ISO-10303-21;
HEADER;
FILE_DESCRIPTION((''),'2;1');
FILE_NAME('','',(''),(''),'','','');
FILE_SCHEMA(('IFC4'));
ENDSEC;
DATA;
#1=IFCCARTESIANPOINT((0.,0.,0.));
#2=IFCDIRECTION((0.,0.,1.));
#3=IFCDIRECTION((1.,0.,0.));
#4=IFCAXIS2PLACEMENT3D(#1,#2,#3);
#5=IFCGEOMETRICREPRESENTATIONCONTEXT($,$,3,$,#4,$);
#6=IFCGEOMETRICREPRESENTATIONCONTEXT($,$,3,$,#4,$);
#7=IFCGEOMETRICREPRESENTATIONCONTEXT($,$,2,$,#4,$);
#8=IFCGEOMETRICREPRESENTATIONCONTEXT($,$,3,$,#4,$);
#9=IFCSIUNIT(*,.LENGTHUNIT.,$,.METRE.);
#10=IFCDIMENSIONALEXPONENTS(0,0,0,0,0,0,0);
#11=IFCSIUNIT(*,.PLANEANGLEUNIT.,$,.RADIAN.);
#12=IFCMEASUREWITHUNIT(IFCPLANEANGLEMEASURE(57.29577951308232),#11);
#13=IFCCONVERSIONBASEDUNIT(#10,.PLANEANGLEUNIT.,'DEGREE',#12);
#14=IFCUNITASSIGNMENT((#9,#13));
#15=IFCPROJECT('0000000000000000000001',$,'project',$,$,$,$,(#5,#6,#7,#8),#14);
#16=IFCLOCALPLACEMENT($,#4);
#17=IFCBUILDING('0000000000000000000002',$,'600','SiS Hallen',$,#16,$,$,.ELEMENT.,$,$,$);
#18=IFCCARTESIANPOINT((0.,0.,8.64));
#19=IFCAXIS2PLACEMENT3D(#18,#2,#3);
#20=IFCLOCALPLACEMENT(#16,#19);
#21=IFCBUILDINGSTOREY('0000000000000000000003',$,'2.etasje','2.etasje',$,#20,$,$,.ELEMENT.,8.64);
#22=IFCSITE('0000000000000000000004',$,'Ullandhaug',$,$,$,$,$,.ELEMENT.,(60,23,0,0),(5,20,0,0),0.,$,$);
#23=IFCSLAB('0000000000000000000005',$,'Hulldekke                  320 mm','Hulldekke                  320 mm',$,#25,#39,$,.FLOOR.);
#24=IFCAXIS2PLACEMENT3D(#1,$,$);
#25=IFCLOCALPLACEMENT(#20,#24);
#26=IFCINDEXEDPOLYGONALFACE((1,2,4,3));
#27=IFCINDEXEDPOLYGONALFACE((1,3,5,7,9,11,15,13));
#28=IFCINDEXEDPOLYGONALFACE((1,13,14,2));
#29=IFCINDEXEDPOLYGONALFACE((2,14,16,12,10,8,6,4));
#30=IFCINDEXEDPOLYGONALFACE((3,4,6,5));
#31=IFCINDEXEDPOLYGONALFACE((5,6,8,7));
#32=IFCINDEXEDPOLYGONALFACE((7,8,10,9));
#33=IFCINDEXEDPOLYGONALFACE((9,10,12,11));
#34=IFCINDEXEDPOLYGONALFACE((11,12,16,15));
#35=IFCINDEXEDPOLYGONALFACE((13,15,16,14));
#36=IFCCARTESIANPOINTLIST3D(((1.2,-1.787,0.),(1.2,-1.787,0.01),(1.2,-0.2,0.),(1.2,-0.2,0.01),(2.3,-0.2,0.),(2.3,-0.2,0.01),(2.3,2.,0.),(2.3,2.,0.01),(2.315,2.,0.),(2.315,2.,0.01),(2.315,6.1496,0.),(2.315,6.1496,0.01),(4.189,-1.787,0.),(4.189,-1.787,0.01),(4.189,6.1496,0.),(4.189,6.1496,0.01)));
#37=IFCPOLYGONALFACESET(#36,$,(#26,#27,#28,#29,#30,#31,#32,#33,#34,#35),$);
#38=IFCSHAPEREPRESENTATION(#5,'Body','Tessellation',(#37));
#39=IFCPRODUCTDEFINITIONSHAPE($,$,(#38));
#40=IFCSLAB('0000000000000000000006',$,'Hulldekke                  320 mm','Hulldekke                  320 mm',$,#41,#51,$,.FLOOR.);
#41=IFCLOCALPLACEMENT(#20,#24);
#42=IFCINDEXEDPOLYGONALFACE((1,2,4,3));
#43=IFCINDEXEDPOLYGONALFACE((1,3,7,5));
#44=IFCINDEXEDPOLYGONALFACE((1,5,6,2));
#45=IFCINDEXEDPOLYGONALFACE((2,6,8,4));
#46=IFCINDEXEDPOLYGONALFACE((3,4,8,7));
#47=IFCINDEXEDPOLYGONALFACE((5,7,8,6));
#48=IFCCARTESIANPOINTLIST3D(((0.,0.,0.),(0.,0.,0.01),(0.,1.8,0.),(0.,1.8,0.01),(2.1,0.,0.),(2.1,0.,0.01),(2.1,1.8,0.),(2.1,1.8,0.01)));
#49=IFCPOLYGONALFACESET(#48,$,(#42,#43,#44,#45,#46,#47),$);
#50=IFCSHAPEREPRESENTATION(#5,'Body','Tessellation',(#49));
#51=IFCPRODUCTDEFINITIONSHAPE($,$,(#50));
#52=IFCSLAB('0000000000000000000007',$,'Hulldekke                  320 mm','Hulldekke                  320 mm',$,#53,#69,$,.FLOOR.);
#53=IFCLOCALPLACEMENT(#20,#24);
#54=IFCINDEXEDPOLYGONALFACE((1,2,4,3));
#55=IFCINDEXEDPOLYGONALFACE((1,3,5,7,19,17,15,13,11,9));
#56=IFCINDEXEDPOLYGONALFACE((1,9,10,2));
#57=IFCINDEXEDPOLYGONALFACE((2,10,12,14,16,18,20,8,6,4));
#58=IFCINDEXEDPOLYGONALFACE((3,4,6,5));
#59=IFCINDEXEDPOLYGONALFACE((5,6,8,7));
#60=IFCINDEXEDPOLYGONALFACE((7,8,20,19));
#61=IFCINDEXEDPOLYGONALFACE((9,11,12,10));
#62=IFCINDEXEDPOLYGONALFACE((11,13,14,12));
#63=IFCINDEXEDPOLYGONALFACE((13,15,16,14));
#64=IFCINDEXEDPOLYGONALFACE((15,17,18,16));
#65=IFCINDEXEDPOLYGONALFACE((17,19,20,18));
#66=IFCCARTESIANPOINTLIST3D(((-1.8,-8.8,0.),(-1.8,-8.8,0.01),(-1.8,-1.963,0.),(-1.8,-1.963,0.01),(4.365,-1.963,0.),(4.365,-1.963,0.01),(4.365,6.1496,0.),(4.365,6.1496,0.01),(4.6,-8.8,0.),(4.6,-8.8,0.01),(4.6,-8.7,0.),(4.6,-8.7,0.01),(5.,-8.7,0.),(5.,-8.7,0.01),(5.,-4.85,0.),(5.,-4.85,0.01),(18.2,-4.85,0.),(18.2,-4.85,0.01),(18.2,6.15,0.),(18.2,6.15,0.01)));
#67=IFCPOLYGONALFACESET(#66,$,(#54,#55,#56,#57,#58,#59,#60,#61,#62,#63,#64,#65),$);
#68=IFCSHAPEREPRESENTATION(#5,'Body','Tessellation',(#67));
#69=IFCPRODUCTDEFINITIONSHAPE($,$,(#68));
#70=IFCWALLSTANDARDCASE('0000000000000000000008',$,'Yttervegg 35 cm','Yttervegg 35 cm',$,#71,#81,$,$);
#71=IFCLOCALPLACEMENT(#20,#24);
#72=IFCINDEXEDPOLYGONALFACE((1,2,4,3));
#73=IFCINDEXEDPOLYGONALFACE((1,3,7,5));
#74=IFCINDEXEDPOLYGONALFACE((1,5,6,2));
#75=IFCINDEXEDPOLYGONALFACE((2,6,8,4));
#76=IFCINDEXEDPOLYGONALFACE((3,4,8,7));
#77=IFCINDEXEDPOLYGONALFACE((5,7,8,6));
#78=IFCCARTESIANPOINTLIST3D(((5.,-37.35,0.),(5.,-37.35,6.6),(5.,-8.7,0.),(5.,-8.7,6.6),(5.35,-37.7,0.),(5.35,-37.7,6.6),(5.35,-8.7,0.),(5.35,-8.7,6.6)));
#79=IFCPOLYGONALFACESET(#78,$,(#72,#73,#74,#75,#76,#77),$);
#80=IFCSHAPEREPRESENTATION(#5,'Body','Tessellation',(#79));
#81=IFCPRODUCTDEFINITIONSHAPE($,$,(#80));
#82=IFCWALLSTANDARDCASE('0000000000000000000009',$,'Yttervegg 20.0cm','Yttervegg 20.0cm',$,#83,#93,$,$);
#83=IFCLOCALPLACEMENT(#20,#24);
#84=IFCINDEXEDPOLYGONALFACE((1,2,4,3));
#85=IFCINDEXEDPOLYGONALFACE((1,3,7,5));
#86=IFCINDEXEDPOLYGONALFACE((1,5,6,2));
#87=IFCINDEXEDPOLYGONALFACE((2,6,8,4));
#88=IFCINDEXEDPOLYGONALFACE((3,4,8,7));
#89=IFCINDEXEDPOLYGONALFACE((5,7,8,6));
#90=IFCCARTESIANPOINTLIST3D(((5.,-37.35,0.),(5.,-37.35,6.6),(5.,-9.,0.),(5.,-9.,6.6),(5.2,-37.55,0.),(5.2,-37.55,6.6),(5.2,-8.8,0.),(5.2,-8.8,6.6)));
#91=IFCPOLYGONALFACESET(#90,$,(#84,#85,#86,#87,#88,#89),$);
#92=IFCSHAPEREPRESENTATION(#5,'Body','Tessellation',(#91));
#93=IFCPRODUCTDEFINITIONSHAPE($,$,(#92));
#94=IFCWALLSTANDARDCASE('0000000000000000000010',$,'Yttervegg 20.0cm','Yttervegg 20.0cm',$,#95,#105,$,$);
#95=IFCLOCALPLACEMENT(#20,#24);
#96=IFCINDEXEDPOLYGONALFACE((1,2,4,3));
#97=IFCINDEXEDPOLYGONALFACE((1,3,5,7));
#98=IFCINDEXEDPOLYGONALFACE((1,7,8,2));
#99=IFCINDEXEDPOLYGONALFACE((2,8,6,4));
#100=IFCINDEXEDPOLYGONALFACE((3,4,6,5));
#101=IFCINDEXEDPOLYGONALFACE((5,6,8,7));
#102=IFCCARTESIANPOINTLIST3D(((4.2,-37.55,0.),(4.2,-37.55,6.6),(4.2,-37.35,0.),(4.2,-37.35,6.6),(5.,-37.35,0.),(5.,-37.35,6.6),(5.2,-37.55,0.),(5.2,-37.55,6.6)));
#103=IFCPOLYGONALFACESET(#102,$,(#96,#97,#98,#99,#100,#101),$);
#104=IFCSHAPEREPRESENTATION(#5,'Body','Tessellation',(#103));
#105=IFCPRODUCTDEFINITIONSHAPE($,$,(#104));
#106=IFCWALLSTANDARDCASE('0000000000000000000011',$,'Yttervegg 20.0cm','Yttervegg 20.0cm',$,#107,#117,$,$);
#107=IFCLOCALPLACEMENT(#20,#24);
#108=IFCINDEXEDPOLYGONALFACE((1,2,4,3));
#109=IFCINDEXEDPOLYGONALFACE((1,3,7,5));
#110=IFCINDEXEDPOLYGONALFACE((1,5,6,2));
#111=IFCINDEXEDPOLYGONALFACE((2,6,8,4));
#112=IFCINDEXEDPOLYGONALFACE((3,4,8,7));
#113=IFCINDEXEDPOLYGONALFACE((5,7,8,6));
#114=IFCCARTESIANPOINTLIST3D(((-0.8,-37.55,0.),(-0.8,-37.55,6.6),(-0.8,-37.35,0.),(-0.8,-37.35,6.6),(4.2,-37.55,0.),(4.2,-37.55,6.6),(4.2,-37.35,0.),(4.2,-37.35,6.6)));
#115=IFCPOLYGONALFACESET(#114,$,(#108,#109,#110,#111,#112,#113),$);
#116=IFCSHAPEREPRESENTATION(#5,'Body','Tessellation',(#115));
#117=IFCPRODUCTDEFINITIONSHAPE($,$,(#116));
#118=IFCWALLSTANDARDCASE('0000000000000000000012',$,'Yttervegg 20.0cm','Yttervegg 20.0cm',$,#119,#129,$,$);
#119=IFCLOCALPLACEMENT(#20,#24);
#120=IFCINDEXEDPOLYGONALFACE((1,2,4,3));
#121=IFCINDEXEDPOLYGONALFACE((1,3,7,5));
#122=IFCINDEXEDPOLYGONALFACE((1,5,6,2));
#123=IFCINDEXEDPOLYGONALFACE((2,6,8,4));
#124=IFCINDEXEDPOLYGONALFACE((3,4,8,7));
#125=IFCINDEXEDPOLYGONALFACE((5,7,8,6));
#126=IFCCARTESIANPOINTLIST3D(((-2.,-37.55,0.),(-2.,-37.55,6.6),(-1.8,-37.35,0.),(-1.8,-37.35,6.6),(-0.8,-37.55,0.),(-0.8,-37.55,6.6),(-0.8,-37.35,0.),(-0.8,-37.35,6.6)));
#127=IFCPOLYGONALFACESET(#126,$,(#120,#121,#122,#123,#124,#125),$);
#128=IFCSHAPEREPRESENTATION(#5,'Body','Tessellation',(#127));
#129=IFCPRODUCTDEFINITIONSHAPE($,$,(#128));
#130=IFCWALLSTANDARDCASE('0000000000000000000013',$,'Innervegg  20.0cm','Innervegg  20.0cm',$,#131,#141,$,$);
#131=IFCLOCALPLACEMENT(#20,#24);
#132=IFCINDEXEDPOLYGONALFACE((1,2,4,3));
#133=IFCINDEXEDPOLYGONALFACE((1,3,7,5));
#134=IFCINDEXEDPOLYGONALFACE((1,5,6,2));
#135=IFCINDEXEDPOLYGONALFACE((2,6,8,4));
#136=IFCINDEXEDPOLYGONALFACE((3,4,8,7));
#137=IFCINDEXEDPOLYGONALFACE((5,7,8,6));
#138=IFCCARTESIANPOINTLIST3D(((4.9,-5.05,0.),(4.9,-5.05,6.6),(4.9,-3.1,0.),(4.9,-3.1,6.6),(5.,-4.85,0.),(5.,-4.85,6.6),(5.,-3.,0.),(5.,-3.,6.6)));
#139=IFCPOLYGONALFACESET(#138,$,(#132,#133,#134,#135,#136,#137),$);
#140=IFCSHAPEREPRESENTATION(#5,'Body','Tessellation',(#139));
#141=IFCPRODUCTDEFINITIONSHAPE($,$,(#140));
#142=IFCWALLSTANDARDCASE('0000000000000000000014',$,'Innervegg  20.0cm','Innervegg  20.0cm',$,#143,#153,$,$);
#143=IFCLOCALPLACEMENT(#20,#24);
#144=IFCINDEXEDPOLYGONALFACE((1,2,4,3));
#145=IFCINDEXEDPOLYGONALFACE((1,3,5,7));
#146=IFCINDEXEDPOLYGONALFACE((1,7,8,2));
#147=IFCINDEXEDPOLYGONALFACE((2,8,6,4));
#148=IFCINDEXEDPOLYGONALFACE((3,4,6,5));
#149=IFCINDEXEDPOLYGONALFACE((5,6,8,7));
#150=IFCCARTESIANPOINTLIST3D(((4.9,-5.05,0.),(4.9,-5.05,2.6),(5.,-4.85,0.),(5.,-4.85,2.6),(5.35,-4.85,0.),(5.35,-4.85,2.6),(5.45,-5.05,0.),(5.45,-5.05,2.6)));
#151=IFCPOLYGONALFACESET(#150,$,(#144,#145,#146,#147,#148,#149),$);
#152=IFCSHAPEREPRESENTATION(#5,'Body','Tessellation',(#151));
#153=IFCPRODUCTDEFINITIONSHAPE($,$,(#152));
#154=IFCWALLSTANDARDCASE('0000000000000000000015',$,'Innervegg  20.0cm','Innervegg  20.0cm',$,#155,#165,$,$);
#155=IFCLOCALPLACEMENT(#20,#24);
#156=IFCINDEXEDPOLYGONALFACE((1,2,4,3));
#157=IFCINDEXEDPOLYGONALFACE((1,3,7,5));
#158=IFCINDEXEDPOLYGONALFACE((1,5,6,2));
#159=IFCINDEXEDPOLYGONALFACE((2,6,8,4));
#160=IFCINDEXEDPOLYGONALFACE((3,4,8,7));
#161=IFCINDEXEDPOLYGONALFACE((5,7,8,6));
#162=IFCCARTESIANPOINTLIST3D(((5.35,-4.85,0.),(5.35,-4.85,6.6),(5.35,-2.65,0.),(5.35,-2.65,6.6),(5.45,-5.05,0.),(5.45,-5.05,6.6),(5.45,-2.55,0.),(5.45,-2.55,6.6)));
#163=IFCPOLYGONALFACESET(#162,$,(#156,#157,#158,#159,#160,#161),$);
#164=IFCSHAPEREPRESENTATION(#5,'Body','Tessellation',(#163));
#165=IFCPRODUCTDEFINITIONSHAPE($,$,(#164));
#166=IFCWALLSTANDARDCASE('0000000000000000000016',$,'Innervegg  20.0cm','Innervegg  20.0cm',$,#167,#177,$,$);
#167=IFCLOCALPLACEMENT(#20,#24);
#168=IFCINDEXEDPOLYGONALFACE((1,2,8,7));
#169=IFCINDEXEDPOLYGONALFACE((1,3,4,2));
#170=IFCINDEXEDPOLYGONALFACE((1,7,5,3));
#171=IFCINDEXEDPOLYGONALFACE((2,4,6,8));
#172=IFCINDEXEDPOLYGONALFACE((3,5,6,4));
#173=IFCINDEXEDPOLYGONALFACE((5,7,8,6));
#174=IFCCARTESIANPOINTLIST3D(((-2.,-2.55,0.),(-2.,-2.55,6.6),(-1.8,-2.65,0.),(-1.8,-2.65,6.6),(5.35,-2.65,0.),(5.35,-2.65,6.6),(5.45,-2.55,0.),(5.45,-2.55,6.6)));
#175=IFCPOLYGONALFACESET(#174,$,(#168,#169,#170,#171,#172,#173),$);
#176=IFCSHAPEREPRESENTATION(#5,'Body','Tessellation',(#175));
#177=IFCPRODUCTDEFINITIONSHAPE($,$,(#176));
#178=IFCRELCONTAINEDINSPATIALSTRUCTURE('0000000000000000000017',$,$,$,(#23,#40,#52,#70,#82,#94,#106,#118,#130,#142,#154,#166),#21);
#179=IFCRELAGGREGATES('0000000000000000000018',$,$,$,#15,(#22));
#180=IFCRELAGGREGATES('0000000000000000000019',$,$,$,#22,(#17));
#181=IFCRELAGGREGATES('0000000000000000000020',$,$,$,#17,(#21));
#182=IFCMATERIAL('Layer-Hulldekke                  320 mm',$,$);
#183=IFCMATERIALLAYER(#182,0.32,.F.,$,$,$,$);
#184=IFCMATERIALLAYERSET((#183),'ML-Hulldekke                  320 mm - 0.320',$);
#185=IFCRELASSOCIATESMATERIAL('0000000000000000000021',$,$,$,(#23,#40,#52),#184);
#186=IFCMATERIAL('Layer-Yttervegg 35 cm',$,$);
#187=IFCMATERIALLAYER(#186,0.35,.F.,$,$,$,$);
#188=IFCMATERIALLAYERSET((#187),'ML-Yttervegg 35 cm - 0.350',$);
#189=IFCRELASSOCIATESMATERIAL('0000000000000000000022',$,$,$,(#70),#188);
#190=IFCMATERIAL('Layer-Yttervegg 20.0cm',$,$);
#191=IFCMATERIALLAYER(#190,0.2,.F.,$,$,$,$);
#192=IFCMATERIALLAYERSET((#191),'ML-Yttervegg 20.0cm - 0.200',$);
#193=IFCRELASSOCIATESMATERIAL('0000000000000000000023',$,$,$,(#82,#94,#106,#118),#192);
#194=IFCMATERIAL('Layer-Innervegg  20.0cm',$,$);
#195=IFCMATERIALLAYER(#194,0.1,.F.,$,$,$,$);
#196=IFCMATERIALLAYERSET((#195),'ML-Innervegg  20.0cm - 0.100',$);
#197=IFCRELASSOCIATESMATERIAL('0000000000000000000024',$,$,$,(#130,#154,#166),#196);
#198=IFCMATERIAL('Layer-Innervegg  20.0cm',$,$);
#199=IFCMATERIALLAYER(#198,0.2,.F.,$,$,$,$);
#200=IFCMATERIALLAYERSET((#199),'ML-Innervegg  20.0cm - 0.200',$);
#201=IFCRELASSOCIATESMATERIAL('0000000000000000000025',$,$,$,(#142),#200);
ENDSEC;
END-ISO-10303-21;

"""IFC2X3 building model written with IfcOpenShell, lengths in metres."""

from ifc_helpers import new_model, entity, si_unit, converted_unit, frame, origin_with_axes, place, context, project, spatial, polyline, outline, extrude, material, layer, layer_set, layer_usage, element, save


model = new_model("IFC2X3")

# Units and contexts
context_of_model_1 = context(None, 3, world=origin_with_axes())
context_of_model_2 = context(None, 3, world=origin_with_axes())
context_of_model_3 = context(None, 2, world=origin_with_axes())
context_of_model_4 = context(None, 3, world=origin_with_axes())
ifc_project = project(units=[si_unit("LENGTHUNIT", "METRE"), converted_unit("PLANEANGLEUNIT", "DEGREE", entity("IfcPlaneAngleMeasure", 57.29577951308232), si_unit("PLANEANGLEUNIT", "RADIAN"), dimensions=[0, 0, 0, 0, 0, 0, 0])], contexts=[context_of_model_1, context_of_model_2, context_of_model_3, context_of_model_4])

# Site, building, storey
site = spatial("IfcSite", under=ifc_project, Name="Ullandhaug", CompositionType="ELEMENT", RefLatitude=(60, 23, 0, 0), RefLongitude=(5, 20, 0, 0), RefElevation=0.0)
building_placement = place(None, origin_with_axes())
building = spatial("IfcBuilding", under=site, at=building_placement, Name="600", Description="SiS Hallen", CompositionType="ELEMENT")
storey_placement = place(building_placement, frame((0.0, 0.0, 8.64), z_axis=(0.0, 0.0, 1.0), x_axis=(1.0, 0.0, 0.0)))
storey = spatial("IfcBuildingStorey", under=building, at=storey_placement, Name="2.etasje", Description="2.etasje", CompositionType="ELEMENT", Elevation=8.64)

# Slabs
ifc_material_1 = material(Name="Layer-Hulldekke                  320 mm")
ifc_layer_1 = layer(ifc_material_1, 0.32, ventilated=False)
ifc_layer_set_1 = layer_set([ifc_layer_1], Name="ML-Hulldekke                  320 mm - 0.320")
ifc_layer_usage_1 = layer_usage(ifc_layer_set_1, "AXIS2", "POSITIVE", 0.0)
slab_1_placement = place(storey_placement, frame((4.189, -1.787, 0.0), z_axis=(0.0, 0.0, 1.0), x_axis=(1.0, 0.0, 0.0)))
element("IfcSlab", 1, at=slab_1_placement, inside=storey, material=ifc_layer_usage_1, Name="Hulldekke                  320 mm", Description="Hulldekke                  320 mm", PredefinedType="FLOOR", context=context_of_model_1, shape_type="SweptSolid", body=[
    extrude(outline(polyline([(0.0, 0.0), (7.9366, 0.0), (7.9366, 1.874), (3.787, 1.874), (3.787, 1.889), (1.587, 1.889), (1.587, 2.989), (0.0, 2.989), (0.0, 0.0)])), frame((0.0, 0.0, 0.0), z_axis=(0.0, 0.0, 1.0), x_axis=(0.0, 1.0, 0.0)), (0.0, 0.0, 1.0), 0.01),
])
slab_2_placement = place(storey_placement, origin_with_axes())
element("IfcSlab", 2, at=slab_2_placement, inside=storey, material=ifc_layer_usage_1, Name="Hulldekke                  320 mm", Description="Hulldekke                  320 mm", PredefinedType="FLOOR", context=context_of_model_1, shape_type="SweptSolid", body=[
    extrude(outline(polyline([(0.0, 0.0), (2.1, 0.0), (2.1, 1.8), (0.0, 1.8), (0.0, 0.0)])), origin_with_axes(), (0.0, 0.0, 1.0), 0.01),
])
slab_3_placement = place(storey_placement, frame((-1.8, -8.8, 0.0), z_axis=(0.0, 0.0, 1.0), x_axis=(1.0, 0.0, 0.0)))
element("IfcSlab", 3, at=slab_3_placement, inside=storey, material=ifc_layer_usage_1, Name="Hulldekke                  320 mm", Description="Hulldekke                  320 mm", PredefinedType="FLOOR", context=context_of_model_1, shape_type="SweptSolid", body=[
    extrude(outline(polyline([(0.0, 0.0), (6.4, 0.0), (6.4, 0.1), (6.8, 0.1), (6.8, 3.95), (20.0, 3.95), (20.0, 14.95), (6.165, 14.9496), (6.165, 6.837), (0.0, 6.837), (0.0, 0.0)])), origin_with_axes(), (0.0, 0.0, 1.0), 0.01),
])

# Walls
ifc_material_2 = material(Name="Layer-Yttervegg 35 cm")
ifc_layer_2 = layer(ifc_material_2, 0.35, ventilated=False)
ifc_layer_set_2 = layer_set([ifc_layer_2], Name="ML-Yttervegg 35 cm - 0.350")
ifc_layer_usage_2 = layer_usage(ifc_layer_set_2, "AXIS2", "POSITIVE", 0.0)
wall_1_placement = place(storey_placement, frame((5.35, -37.7, 0.0), z_axis=(0.0, 0.0, 1.0), x_axis=(0.0, 1.0, 0.0)))
element("IfcWallStandardCase", 4, at=wall_1_placement, inside=storey, material=ifc_layer_usage_2, Name="Yttervegg 35 cm", Description="Yttervegg 35 cm", context=context_of_model_1, shape_type="SweptSolid", body=[
    extrude(outline(polyline([(0.0, 0.0), (29.0, 0.0), (29.0, 0.35), (0.35, 0.35), (0.0, 0.0)])), frame((0.0, 0.0, 0.0), z_axis=(0.0, 0.0, 1.0), x_axis=(1.0, 0.0, 0.0)), (0.0, 0.0, 1.0), 6.6),
])
ifc_material_3 = material(Name="Layer-Yttervegg 20.0cm")
ifc_layer_3 = layer(ifc_material_3, 0.2, ventilated=False)
ifc_layer_set_3 = layer_set([ifc_layer_3], Name="ML-Yttervegg 20.0cm - 0.200")
ifc_layer_usage_3 = layer_usage(ifc_layer_set_3, "AXIS2", "POSITIVE", 0.0)
wall_2_placement = place(storey_placement, frame((5.0, -9.0, 0.0), z_axis=(0.0, 0.0, 1.0), x_axis=(0.0, -1.0, 0.0)))
element("IfcWallStandardCase", 5, at=wall_2_placement, inside=storey, material=ifc_layer_usage_3, Name="Yttervegg 20.0cm", Description="Yttervegg 20.0cm", context=context_of_model_1, shape_type="SweptSolid", body=[
    extrude(outline(polyline([(0.0, 0.0), (28.35, 0.0), (28.55, 0.2), (-0.2, 0.2), (0.0, 0.0)])), frame((0.0, 0.0, 0.0), z_axis=(0.0, 0.0, 1.0), x_axis=(1.0, 0.0, 0.0)), (0.0, 0.0, 1.0), 6.6),
])
wall_3_placement = place(storey_placement, frame((5.0, -37.35, 0.0), z_axis=(0.0, 0.0, 1.0), x_axis=(-1.0, 0.0, 0.0)))
element("IfcWallStandardCase", 6, at=wall_3_placement, inside=storey, material=ifc_layer_usage_3, Name="Yttervegg 20.0cm", Description="Yttervegg 20.0cm", context=context_of_model_1, shape_type="SweptSolid", body=[
    extrude(outline(polyline([(0.0, 0.0), (0.8, 0.0), (0.8, 0.2), (-0.2, 0.2), (0.0, 0.0)])), frame((0.0, 0.0, 0.0), z_axis=(0.0, 0.0, 1.0), x_axis=(1.0, 0.0, 0.0)), (0.0, 0.0, 1.0), 6.6),
])
wall_4_placement = place(storey_placement, frame((4.2, -37.35, 0.0), z_axis=(0.0, 0.0, 1.0), x_axis=(-1.0, 0.0, 0.0)))
element("IfcWallStandardCase", 7, at=wall_4_placement, inside=storey, material=ifc_layer_usage_3, Name="Yttervegg 20.0cm", Description="Yttervegg 20.0cm", context=context_of_model_1, shape_type="SweptSolid", body=[
    extrude(outline(polyline([(0.0, 0.0), (5.0, 0.0), (5.0, 0.2), (0.0, 0.2), (0.0, 0.0)])), frame((0.0, 0.0, 0.0), z_axis=(0.0, 0.0, 1.0), x_axis=(1.0, 0.0, 0.0)), (0.0, 0.0, 1.0), 6.6),
])
wall_5_placement = place(storey_placement, frame((-0.8, -37.35, 0.0), z_axis=(0.0, 0.0, 1.0), x_axis=(-1.0, 0.0, 0.0)))
element("IfcWallStandardCase", 8, at=wall_5_placement, inside=storey, material=ifc_layer_usage_3, Name="Yttervegg 20.0cm", Description="Yttervegg 20.0cm", context=context_of_model_1, shape_type="SweptSolid", body=[
    extrude(outline(polyline([(0.0, 0.0), (1.0, 0.0), (1.2, 0.2), (0.0, 0.2), (0.0, 0.0)])), frame((0.0, 0.0, 0.0), z_axis=(0.0, 0.0, 1.0), x_axis=(1.0, 0.0, 0.0)), (0.0, 0.0, 1.0), 6.6),
])
ifc_material_4 = material(Name="Layer-Innervegg  20.0cm")
ifc_layer_4 = layer(ifc_material_4, 0.1, ventilated=False)
ifc_layer_set_4 = layer_set([ifc_layer_4], Name="ML-Innervegg  20.0cm - 0.100")
ifc_layer_usage_4 = layer_usage(ifc_layer_set_4, "AXIS2", "POSITIVE", 0.0)
wall_6_placement = place(storey_placement, frame((4.9, -3.1, 0.0), z_axis=(0.0, 0.0, 1.0), x_axis=(0.0, -1.0, 0.0)))
element("IfcWallStandardCase", 9, at=wall_6_placement, inside=storey, material=ifc_layer_usage_4, Name="Innervegg  20.0cm", Description="Innervegg  20.0cm", context=context_of_model_1, shape_type="SweptSolid", body=[
    extrude(outline(polyline([(0.0, 0.0), (1.95, 0.0), (1.75, 0.1), (-0.1, 0.1), (0.0, 0.0)])), frame((0.0, 0.0, 0.0), z_axis=(0.0, 0.0, 1.0), x_axis=(1.0, 0.0, 0.0)), (0.0, 0.0, 1.0), 6.6),
])
ifc_material_5 = material(Name="Layer-Innervegg  20.0cm")
ifc_layer_5 = layer(ifc_material_5, 0.2, ventilated=False)
ifc_layer_set_5 = layer_set([ifc_layer_5], Name="ML-Innervegg  20.0cm - 0.200")
ifc_layer_usage_5 = layer_usage(ifc_layer_set_5, "AXIS2", "POSITIVE", 0.0)
wall_7_placement = place(storey_placement, frame((4.9, -5.05, 0.0), z_axis=(0.0, 0.0, 1.0), x_axis=(1.0, 0.0, 0.0)))
element("IfcWallStandardCase", 10, at=wall_7_placement, inside=storey, material=ifc_layer_usage_5, Name="Innervegg  20.0cm", Description="Innervegg  20.0cm", context=context_of_model_1, shape_type="SweptSolid", body=[
    extrude(outline(polyline([(0.0, 0.0), (0.55, 0.0), (0.45, 0.2), (0.1, 0.2), (0.0, 0.0)])), origin_with_axes(), (0.0, 0.0, 1.0), 2.6),
])
wall_8_placement = place(storey_placement, frame((5.45, -5.05, 0.0), z_axis=(0.0, 0.0, 1.0), x_axis=(0.0, 1.0, 0.0)))
element("IfcWallStandardCase", 11, at=wall_8_placement, inside=storey, material=ifc_layer_usage_4, Name="Innervegg  20.0cm", Description="Innervegg  20.0cm", context=context_of_model_1, shape_type="SweptSolid", body=[
    extrude(outline(polyline([(0.0, 0.0), (2.5, 0.0), (2.4, 0.1), (0.2, 0.1), (0.0, 0.0)])), frame((0.0, 0.0, 0.0), z_axis=(0.0, 0.0, 1.0), x_axis=(1.0, 0.0, 0.0)), (0.0, 0.0, 1.0), 6.6),
])
wall_9_placement = place(storey_placement, frame((5.45, -2.55, 0.0), z_axis=(0.0, 0.0, 1.0), x_axis=(-1.0, 0.0, 0.0)))
element("IfcWallStandardCase", 12, at=wall_9_placement, inside=storey, material=ifc_layer_usage_4, Name="Innervegg  20.0cm", Description="Innervegg  20.0cm", context=context_of_model_1, shape_type="SweptSolid", body=[
    extrude(outline(polyline([(0.0, 0.0), (7.45, 0.0), (7.25, 0.1), (0.1, 0.1), (0.0, 0.0)])), frame((0.0, 0.0, 0.0), z_axis=(0.0, 0.0, 1.0), x_axis=(1.0, 0.0, 0.0)), (0.0, 0.0, 1.0), 6.6),
])

save(model, "model.ifc")
